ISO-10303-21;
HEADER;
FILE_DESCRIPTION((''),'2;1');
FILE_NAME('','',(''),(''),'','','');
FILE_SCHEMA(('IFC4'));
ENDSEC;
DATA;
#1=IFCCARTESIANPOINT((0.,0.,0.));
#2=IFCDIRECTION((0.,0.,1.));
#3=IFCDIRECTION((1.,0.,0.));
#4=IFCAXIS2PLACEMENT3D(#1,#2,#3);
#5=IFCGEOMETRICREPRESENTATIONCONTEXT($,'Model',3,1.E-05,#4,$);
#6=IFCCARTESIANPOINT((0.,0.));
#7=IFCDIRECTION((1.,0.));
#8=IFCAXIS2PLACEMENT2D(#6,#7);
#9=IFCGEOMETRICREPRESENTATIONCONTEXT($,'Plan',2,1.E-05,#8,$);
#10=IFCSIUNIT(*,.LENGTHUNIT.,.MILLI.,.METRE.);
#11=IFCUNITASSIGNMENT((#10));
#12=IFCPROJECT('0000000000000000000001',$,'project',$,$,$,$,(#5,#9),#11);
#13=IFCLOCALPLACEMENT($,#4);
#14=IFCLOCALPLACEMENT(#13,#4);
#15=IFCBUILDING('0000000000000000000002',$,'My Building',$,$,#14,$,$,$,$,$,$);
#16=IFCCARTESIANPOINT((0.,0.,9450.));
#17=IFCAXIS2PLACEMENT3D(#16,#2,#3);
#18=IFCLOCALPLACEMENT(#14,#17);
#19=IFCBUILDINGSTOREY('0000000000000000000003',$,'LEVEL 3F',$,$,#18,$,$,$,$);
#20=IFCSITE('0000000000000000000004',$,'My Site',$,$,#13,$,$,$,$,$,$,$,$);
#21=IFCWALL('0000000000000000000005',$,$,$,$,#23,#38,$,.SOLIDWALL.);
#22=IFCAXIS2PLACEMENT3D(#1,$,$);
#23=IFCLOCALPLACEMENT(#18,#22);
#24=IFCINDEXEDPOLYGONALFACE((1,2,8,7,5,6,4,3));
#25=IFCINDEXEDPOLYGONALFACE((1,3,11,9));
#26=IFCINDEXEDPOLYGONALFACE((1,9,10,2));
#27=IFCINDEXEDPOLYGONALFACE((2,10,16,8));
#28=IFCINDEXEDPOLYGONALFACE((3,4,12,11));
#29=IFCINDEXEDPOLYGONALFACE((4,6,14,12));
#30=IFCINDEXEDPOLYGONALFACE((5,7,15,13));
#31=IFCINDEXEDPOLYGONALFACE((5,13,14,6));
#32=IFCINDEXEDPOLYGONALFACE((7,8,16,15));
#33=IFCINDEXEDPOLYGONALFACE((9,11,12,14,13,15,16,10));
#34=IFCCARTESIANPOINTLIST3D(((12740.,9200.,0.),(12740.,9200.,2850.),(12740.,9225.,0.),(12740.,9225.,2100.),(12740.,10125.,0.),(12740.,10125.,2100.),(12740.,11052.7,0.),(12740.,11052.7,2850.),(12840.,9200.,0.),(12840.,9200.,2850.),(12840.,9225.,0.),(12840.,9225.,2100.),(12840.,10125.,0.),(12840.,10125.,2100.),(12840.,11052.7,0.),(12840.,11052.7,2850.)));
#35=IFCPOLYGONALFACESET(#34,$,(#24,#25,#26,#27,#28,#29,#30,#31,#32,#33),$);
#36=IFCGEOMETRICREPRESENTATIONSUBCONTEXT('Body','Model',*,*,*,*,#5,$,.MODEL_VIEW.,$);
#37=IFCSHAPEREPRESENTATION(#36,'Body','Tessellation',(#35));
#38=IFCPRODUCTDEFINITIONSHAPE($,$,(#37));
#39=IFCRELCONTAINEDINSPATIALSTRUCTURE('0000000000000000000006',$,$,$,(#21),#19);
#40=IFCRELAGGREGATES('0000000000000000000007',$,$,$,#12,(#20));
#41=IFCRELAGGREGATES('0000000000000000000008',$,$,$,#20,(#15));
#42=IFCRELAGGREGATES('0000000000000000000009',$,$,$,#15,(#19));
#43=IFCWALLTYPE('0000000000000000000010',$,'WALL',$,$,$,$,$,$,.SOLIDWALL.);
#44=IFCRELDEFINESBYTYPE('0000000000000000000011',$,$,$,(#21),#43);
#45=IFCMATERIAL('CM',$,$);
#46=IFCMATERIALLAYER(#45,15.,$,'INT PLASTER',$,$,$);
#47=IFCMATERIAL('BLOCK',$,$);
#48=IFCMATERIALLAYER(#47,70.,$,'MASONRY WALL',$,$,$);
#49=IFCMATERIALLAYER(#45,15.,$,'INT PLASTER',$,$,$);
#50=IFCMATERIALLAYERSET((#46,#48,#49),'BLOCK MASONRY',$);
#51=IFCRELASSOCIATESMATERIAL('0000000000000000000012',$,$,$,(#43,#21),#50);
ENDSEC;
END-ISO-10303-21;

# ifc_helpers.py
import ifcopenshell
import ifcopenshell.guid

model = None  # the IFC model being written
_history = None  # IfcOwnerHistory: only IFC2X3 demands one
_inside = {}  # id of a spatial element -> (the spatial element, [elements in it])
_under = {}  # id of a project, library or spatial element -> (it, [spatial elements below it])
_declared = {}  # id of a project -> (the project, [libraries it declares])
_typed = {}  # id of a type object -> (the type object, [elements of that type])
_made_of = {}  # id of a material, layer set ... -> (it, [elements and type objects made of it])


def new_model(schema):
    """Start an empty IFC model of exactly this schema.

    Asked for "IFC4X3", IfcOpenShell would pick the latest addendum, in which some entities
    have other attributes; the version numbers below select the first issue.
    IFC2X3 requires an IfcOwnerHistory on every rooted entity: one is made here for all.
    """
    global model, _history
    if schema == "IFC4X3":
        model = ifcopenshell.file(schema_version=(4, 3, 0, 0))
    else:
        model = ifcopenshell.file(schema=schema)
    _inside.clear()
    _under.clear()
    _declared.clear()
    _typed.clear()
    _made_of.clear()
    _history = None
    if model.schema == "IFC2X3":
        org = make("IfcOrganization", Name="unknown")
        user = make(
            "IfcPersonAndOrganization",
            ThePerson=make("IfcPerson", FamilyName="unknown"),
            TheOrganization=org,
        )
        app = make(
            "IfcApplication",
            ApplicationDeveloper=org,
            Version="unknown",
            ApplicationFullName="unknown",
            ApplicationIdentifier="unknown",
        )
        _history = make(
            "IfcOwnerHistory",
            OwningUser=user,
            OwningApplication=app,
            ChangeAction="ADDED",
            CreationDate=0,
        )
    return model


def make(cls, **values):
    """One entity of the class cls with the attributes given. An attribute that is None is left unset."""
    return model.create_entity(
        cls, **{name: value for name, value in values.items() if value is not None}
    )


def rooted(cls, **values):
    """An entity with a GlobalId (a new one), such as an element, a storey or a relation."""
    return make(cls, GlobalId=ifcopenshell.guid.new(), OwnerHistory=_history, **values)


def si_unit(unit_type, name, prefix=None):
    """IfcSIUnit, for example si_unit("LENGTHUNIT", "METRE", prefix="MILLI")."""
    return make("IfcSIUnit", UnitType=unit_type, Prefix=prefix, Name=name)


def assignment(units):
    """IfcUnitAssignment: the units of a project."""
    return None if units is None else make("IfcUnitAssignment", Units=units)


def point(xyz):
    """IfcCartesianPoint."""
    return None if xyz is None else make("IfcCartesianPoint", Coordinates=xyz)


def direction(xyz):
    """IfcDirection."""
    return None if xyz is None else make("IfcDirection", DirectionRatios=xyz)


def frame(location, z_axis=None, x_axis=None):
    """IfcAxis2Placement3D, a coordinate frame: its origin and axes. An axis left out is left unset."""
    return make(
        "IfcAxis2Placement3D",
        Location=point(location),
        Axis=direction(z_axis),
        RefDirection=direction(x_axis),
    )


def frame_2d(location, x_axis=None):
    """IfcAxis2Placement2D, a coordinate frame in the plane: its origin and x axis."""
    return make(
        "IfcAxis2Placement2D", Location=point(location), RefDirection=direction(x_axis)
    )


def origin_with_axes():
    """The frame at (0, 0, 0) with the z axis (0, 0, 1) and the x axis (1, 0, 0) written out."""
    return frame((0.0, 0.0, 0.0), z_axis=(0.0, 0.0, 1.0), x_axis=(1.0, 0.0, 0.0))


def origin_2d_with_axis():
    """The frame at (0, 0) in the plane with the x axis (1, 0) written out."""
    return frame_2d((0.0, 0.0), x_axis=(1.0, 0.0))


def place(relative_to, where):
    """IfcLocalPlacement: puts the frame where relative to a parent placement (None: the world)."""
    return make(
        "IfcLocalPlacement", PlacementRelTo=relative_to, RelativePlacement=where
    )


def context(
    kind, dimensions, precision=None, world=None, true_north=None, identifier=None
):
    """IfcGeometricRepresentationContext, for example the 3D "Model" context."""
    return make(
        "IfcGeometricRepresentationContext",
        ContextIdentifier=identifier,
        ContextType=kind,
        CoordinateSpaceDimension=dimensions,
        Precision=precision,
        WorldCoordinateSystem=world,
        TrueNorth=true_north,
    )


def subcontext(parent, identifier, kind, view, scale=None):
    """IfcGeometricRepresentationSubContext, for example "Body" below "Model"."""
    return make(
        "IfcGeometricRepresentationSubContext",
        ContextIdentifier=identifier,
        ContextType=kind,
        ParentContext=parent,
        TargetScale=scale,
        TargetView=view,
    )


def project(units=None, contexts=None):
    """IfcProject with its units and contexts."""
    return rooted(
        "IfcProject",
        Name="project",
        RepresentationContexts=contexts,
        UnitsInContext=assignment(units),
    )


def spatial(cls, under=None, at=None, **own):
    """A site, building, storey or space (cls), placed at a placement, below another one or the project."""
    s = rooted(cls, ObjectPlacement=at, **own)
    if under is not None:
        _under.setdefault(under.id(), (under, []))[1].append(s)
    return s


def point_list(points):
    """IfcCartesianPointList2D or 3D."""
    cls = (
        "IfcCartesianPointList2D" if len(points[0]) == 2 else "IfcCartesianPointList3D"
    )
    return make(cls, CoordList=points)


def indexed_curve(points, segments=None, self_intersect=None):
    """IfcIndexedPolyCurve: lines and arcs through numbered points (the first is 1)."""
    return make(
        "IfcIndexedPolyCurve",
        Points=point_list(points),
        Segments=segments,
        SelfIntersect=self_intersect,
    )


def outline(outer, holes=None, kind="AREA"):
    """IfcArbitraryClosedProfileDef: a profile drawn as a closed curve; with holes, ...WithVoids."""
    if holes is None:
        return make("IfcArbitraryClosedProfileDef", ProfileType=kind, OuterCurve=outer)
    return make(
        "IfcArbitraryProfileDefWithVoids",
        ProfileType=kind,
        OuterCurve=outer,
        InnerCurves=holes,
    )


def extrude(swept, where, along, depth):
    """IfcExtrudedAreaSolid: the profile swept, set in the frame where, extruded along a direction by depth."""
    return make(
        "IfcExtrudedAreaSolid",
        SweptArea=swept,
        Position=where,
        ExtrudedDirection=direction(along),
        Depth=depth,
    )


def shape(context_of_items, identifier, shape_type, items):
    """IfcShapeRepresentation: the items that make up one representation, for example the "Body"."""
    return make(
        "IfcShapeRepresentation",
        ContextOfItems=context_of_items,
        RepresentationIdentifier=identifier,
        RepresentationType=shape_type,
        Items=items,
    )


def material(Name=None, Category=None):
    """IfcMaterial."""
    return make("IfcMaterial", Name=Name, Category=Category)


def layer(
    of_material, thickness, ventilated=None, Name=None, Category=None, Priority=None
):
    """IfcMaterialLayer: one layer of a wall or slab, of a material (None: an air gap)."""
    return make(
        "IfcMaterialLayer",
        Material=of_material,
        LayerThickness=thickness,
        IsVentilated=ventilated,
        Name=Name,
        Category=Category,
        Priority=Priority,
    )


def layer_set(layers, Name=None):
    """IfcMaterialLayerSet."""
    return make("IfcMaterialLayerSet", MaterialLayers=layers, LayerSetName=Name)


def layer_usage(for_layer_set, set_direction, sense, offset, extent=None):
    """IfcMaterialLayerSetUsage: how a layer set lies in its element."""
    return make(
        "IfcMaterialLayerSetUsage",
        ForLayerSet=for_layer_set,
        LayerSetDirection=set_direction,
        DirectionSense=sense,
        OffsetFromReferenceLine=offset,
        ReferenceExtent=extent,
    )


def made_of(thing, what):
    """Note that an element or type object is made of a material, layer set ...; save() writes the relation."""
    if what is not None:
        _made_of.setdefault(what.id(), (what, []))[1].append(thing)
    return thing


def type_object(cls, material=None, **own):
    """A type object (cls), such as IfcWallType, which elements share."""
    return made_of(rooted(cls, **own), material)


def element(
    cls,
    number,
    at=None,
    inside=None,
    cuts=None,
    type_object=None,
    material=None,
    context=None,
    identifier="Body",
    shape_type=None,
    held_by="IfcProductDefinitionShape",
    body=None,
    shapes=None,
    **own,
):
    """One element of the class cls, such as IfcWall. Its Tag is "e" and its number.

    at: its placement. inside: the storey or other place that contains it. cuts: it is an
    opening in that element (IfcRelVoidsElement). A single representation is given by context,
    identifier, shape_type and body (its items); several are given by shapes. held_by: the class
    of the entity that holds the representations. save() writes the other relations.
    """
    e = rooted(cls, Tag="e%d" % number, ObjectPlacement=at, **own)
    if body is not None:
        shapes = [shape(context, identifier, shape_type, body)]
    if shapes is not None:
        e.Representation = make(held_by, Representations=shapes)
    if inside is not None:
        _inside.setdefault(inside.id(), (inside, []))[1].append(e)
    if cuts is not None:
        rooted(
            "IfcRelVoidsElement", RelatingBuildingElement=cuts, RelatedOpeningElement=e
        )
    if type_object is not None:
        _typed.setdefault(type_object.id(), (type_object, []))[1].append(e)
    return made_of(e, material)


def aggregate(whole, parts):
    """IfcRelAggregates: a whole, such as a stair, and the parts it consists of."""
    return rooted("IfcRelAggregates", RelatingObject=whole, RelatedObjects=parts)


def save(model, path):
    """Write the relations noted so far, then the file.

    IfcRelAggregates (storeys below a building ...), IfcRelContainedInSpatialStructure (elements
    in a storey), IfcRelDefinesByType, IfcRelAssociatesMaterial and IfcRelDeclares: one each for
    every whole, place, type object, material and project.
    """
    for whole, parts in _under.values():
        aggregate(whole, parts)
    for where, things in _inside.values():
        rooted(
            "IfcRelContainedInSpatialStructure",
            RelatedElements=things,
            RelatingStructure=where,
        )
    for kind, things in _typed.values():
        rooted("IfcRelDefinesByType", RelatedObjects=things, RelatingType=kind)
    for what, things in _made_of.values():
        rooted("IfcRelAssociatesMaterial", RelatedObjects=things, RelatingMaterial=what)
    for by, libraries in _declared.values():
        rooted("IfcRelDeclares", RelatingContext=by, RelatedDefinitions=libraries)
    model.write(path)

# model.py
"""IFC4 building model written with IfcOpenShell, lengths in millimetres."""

from ifc_helpers import new_model, si_unit, frame, origin_with_axes, origin_2d_with_axis, place, context, subcontext, project, spatial, indexed_curve, outline, extrude, material, layer, layer_set, layer_usage, type_object, element, save


model = new_model("IFC4")

# Units and contexts
model_context = context("Model", 3, precision=1e-05, world=origin_with_axes())
plan_context = context("Plan", 2, precision=1e-05, world=origin_2d_with_axis())
body_context = subcontext(model_context, "Body", "Model", "MODEL_VIEW")
ifc_project = project(units=[si_unit("LENGTHUNIT", "METRE", prefix="MILLI")], contexts=[model_context, plan_context])

# Site, building, storey
site_placement = place(None, origin_with_axes())
site = spatial("IfcSite", under=ifc_project, at=site_placement, Name="My Site")
building_placement = place(site_placement, origin_with_axes())
building = spatial("IfcBuilding", under=site, at=building_placement, Name="My Building")
storey_placement = place(building_placement, frame((0.0, 0.0, 9450.0), z_axis=(0.0, 0.0, 1.0), x_axis=(1.0, 0.0, 0.0)))
storey = spatial("IfcBuildingStorey", under=building, at=storey_placement, Name="LEVEL 3F")

# Shared definitions
ifc_material_1 = material(Name="CM")
ifc_layer_1 = layer(ifc_material_1, 15.0, Name="INT PLASTER")
ifc_material_2 = material(Name="BLOCK")
ifc_layer_2 = layer(ifc_material_2, 70.0, Name="MASONRY WALL")
ifc_layer_3 = layer(ifc_material_1, 15.0, Name="INT PLASTER")
ifc_layer_set = layer_set([ifc_layer_1, ifc_layer_2, ifc_layer_3], Name="BLOCK MASONRY")
wall_type = type_object("IfcWallType", Name="WALL", PredefinedType="SOLIDWALL", material=ifc_layer_set)

# Wall, opening
ifc_layer_usage_1 = layer_usage(ifc_layer_set, "AXIS2", "POSITIVE", 0.0)
wall_1_placement = place(storey_placement, frame((12840.0, 9200.0, 0.0), z_axis=(0.0, 0.0, 1.0), x_axis=(0.0, 1.0, 0.0)))
wall_1 = element("IfcWall", 1, at=wall_1_placement, inside=storey, type_object=wall_type, material=ifc_layer_usage_1, PredefinedType="SOLIDWALL", context=body_context, shape_type="SweptSolid", body=[
    extrude(outline(indexed_curve([(0.0, 0.0), (0.0, 100.0), (1852.7, 100.0), (1852.7, 0.0), (0.0, 0.0)], self_intersect=False)), origin_with_axes(), (0.0, 0.0, 1.0), 2850.0),
])
opening_1_placement = place(wall_1_placement, frame((925.0, 100.0, 0.0), z_axis=(0.0, 0.0, 1.0), x_axis=(-1.0, 0.0, 0.0)))
element("IfcOpeningElement", 2, at=opening_1_placement, cuts=wall_1, PredefinedType="OPENING", context=body_context, shape_type="SweptSolid", body=[
    extrude(outline(indexed_curve([(0.0, 0.0), (0.0, 400.0), (900.0, 400.0), (900.0, 0.0), (0.0, 0.0)], self_intersect=False)), frame((0.0, -100.0, 0.0), z_axis=(0.0, 0.0, 1.0), x_axis=(1.0, 0.0, 0.0)), (0.0, 0.0, 1.0), 2100.0),
])

save(model, "model.ifc")
